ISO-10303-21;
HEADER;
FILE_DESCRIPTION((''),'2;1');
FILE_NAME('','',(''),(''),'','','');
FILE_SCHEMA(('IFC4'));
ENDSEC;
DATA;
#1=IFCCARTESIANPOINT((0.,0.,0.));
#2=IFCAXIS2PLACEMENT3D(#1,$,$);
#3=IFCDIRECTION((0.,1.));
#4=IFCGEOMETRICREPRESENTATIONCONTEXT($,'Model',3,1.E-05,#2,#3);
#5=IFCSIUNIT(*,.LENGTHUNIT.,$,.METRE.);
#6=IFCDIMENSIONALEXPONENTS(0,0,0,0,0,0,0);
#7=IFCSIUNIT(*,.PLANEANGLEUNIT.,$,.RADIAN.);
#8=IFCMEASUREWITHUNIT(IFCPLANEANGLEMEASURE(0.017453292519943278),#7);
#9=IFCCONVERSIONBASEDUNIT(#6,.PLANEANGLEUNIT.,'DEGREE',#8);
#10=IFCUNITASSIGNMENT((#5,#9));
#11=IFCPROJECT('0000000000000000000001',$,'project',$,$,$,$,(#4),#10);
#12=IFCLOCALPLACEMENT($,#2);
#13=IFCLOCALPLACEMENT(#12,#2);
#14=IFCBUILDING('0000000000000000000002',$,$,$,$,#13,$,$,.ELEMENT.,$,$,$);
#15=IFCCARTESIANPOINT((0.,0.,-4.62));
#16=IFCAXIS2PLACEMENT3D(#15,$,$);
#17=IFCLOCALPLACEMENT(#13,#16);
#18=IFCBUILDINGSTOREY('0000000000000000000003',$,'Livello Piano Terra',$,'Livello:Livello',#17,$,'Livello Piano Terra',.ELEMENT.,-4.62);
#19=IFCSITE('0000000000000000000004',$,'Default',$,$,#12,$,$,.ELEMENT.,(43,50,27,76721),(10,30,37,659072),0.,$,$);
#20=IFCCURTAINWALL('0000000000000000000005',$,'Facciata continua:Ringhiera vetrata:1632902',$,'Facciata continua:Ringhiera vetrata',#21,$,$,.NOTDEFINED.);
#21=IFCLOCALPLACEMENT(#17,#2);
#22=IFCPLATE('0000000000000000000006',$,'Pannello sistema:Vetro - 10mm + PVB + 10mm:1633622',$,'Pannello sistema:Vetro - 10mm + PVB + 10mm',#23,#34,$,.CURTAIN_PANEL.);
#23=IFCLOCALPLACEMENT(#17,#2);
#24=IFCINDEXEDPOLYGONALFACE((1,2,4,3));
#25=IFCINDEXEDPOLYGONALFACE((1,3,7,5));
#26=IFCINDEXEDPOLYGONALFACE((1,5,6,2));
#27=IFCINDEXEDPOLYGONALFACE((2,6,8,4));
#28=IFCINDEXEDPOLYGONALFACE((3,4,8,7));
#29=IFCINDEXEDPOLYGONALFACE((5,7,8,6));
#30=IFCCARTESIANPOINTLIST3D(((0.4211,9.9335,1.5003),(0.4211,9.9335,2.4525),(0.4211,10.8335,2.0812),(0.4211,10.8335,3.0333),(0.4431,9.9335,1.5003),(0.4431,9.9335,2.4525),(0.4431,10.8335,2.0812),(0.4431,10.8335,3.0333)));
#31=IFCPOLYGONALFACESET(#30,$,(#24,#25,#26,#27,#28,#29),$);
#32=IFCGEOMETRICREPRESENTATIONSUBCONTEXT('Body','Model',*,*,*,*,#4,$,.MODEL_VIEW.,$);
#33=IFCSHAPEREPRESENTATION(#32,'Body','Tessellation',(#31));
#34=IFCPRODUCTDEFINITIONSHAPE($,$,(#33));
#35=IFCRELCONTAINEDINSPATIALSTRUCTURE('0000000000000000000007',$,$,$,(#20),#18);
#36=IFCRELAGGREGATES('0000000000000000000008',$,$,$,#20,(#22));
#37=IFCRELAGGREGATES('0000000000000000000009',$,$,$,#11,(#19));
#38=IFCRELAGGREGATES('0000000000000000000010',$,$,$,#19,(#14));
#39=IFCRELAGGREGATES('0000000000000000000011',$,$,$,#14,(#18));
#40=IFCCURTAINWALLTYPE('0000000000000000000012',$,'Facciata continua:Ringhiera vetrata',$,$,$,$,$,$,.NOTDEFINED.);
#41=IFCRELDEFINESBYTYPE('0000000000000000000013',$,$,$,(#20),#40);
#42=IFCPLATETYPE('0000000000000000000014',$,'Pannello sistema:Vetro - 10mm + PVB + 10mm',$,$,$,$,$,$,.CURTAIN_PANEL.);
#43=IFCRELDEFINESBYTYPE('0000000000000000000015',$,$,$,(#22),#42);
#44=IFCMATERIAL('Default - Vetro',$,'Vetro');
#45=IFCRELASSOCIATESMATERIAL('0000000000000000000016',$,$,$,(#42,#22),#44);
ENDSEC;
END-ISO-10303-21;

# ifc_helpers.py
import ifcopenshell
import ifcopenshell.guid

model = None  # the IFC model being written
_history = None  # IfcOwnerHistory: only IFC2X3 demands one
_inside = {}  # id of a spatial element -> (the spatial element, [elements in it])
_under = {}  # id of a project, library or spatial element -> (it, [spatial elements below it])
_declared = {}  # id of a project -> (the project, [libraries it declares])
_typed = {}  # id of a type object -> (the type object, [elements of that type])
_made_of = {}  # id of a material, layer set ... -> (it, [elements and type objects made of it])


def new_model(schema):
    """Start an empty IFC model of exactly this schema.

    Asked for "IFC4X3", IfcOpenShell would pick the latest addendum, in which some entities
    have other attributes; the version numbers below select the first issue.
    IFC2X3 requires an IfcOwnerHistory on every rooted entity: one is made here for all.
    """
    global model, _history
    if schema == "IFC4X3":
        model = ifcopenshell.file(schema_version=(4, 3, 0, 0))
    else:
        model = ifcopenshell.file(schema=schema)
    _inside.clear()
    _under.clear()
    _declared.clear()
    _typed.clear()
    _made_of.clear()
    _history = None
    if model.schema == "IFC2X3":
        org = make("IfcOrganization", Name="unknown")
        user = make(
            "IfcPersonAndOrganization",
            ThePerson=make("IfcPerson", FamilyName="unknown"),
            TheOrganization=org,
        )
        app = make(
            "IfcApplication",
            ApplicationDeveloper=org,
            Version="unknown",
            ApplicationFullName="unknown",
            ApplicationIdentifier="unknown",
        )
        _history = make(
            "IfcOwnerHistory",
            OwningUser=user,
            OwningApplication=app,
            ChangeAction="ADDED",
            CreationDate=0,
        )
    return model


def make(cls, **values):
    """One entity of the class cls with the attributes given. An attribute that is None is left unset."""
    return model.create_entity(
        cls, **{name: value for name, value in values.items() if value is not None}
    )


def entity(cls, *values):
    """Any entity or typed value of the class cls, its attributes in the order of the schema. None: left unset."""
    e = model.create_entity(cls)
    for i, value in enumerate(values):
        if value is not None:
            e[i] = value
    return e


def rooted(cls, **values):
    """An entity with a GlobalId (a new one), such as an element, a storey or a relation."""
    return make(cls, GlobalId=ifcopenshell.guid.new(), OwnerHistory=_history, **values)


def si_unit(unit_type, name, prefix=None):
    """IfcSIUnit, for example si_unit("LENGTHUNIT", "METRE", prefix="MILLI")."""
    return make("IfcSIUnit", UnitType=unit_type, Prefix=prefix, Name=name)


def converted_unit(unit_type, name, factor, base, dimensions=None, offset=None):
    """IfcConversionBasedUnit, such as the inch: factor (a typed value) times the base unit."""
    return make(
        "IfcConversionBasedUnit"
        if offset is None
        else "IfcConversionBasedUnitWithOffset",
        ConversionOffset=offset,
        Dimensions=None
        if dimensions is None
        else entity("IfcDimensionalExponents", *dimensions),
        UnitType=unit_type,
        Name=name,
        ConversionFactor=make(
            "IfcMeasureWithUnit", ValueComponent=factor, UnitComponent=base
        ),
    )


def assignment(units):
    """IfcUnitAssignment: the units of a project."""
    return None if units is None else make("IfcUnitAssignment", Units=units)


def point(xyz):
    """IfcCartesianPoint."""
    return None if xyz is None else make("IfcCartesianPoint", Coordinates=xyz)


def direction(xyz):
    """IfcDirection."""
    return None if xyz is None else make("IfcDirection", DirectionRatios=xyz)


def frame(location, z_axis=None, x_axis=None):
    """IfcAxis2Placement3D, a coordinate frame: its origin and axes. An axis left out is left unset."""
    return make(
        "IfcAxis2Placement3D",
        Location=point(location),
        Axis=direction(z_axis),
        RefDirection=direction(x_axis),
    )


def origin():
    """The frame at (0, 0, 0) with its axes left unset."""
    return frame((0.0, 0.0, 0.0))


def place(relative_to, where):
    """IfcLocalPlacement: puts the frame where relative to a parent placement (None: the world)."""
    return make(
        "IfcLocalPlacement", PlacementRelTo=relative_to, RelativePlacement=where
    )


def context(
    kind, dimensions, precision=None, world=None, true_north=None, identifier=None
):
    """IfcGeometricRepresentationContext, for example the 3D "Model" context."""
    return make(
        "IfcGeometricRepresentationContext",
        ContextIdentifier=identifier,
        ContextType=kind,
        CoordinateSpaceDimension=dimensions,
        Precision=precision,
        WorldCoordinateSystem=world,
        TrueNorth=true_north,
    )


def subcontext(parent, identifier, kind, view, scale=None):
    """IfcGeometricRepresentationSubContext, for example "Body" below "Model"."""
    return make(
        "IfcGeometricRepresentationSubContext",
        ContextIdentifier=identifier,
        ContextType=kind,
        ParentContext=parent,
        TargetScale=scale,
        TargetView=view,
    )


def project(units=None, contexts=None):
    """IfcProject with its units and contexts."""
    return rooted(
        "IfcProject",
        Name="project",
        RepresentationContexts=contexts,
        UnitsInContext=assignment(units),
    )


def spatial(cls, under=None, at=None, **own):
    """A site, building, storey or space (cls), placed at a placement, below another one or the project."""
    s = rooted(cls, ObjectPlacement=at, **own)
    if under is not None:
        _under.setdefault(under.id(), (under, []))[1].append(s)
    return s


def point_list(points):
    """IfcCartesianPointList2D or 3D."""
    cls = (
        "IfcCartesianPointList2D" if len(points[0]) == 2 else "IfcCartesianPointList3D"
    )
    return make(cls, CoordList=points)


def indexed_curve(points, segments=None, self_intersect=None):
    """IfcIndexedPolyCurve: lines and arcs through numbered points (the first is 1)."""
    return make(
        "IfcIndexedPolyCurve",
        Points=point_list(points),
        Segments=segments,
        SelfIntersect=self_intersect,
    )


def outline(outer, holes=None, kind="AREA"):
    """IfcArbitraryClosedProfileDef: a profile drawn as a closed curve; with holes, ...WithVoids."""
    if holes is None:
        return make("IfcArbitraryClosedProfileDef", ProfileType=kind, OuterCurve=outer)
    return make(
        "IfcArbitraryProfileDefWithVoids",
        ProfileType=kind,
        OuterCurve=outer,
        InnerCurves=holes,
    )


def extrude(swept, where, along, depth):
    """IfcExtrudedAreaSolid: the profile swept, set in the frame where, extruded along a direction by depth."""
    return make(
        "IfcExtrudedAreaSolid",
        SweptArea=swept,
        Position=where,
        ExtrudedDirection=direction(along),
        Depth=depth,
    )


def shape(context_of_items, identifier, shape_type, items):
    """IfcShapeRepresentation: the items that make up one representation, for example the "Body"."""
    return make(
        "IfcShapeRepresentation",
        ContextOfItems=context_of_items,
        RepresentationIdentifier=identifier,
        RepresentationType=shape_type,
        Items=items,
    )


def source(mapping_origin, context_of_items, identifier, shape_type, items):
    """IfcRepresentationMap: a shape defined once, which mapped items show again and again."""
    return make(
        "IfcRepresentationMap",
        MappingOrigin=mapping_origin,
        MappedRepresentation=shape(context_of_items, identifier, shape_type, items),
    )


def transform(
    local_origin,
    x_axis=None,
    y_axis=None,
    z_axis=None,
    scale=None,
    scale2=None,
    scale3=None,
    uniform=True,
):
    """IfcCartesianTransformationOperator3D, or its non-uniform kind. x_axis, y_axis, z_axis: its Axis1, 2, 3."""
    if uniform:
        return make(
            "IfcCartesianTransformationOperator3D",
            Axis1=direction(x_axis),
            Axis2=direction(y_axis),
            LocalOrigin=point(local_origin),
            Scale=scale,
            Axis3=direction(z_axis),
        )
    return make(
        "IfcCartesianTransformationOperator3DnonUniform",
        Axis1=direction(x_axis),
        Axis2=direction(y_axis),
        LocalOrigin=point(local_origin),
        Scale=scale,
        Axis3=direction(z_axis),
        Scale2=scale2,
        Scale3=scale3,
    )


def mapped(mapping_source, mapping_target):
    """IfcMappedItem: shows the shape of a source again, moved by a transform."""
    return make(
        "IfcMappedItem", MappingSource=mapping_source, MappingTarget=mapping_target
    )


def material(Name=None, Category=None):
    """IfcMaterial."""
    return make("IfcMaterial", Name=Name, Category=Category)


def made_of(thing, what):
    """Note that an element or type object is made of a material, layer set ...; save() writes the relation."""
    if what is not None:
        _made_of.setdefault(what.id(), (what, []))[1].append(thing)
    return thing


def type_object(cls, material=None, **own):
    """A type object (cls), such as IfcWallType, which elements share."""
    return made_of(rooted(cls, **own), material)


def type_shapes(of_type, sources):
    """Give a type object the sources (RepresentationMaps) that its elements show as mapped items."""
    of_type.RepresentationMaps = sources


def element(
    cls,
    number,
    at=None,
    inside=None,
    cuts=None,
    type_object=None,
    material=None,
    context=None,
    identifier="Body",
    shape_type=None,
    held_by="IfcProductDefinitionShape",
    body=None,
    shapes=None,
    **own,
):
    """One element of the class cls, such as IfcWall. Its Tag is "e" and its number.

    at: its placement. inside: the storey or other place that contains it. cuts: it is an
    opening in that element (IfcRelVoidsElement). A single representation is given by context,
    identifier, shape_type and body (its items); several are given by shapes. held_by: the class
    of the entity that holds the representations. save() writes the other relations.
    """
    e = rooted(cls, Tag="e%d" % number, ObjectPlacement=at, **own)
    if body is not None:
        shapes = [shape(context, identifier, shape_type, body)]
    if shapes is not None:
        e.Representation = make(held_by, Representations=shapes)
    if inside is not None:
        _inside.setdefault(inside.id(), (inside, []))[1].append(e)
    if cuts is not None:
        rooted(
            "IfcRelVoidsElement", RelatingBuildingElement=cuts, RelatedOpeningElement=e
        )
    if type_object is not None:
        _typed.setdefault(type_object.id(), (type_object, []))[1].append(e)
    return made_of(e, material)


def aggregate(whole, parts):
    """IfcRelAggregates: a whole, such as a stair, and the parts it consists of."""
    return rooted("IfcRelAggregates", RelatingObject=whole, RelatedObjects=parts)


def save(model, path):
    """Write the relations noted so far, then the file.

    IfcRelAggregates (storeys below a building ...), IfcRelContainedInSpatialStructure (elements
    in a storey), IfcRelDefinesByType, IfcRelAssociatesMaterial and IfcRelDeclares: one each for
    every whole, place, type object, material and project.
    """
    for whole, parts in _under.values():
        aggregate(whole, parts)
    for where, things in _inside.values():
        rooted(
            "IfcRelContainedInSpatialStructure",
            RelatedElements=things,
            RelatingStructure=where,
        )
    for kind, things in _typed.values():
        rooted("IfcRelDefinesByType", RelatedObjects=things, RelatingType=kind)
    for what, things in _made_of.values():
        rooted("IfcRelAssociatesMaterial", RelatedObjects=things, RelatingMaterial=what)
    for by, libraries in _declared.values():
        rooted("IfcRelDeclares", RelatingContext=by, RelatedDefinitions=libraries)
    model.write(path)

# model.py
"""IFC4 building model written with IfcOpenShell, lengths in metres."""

from ifc_helpers import new_model, entity, si_unit, converted_unit, direction, frame, origin, place, context, subcontext, project, spatial, indexed_curve, outline, extrude, source, transform, mapped, material, type_object, type_shapes, element, aggregate, save


model = new_model("IFC4")

# Units and contexts
model_context = context("Model", 3, precision=1e-05, world=origin(), true_north=direction((0.0, 1.0)))
body_context = subcontext(model_context, "Body", "Model", "MODEL_VIEW")
ifc_project = project(units=[si_unit("LENGTHUNIT", "METRE"), converted_unit("PLANEANGLEUNIT", "DEGREE", entity("IfcPlaneAngleMeasure", 0.017453292519943278), si_unit("PLANEANGLEUNIT", "RADIAN"), dimensions=[0, 0, 0, 0, 0, 0, 0])], contexts=[model_context])

# Site, building, storey
site_placement = place(None, origin())
site = spatial("IfcSite", under=ifc_project, at=site_placement, Name="Default", CompositionType="ELEMENT", RefLatitude=(43, 50, 27, 76721), RefLongitude=(10, 30, 37, 659072), RefElevation=0.0)
building_placement = place(site_placement, origin())
building = spatial("IfcBuilding", under=site, at=building_placement, CompositionType="ELEMENT")
storey_placement = place(building_placement, frame((0.0, 0.0, -4.62)))
storey = spatial("IfcBuildingStorey", under=building, at=storey_placement, Name="Livello Piano Terra", ObjectType="Livello:Livello", LongName="Livello Piano Terra", CompositionType="ELEMENT", Elevation=-4.62)

# Curtain wall, plate
curtain_wall_type = type_object("IfcCurtainWallType", Name="Facciata continua:Ringhiera vetrata", PredefinedType="NOTDEFINED")
curtain_wall_placement = place(storey_placement, frame((0.0, 0.0, 4.62)))
curtain_wall = element("IfcCurtainWall", 1, at=curtain_wall_placement, inside=storey, type_object=curtain_wall_type, Name="Facciata continua:Ringhiera vetrata:1632902", ObjectType="Facciata continua:Ringhiera vetrata", PredefinedType="NOTDEFINED")
ifc_material_1 = material(Name="Default - Vetro", Category="Vetro")
plate_type = type_object("IfcPlateType", Name="Pannello sistema:Vetro - 10mm + PVB + 10mm", PredefinedType="CURTAIN_PANEL", material=ifc_material_1)
shared_shape_1 = source(origin(), body_context, "Body", "SweptSolid", [
    extrude(outline(indexed_curve([(-0.7665, -0.45), (0.1856, -0.45), (0.7665, 0.45), (-0.1856, 0.45), (-0.7665, -0.45)], self_intersect=False)), frame((0.0, -0.011, 0.7665), z_axis=(0.0, 1.0, 0.0), x_axis=(0.0, 0.0, 1.0)), (0.0, 0.0, 1.0), 0.022),
])
type_shapes(plate_type, [shared_shape_1])
plate_1_placement = place(curtain_wall_placement, frame((0.4321, 10.3835, -3.1197), z_axis=(0.0, 0.0, 1.0), x_axis=(0.0, 1.0, 0.0)))
plate_1 = element("IfcPlate", 2, at=plate_1_placement, type_object=plate_type, material=ifc_material_1, Name="Pannello sistema:Vetro - 10mm + PVB + 10mm:1633622", ObjectType="Pannello sistema:Vetro - 10mm + PVB + 10mm", PredefinedType="CURTAIN_PANEL", context=body_context, shape_type="MappedRepresentation", body=[
    mapped(shared_shape_1, transform((0.0, 0.0, 0.0), scale=1.0)),
])
aggregate(curtain_wall, [plate_1])

save(model, "model.ifc")
